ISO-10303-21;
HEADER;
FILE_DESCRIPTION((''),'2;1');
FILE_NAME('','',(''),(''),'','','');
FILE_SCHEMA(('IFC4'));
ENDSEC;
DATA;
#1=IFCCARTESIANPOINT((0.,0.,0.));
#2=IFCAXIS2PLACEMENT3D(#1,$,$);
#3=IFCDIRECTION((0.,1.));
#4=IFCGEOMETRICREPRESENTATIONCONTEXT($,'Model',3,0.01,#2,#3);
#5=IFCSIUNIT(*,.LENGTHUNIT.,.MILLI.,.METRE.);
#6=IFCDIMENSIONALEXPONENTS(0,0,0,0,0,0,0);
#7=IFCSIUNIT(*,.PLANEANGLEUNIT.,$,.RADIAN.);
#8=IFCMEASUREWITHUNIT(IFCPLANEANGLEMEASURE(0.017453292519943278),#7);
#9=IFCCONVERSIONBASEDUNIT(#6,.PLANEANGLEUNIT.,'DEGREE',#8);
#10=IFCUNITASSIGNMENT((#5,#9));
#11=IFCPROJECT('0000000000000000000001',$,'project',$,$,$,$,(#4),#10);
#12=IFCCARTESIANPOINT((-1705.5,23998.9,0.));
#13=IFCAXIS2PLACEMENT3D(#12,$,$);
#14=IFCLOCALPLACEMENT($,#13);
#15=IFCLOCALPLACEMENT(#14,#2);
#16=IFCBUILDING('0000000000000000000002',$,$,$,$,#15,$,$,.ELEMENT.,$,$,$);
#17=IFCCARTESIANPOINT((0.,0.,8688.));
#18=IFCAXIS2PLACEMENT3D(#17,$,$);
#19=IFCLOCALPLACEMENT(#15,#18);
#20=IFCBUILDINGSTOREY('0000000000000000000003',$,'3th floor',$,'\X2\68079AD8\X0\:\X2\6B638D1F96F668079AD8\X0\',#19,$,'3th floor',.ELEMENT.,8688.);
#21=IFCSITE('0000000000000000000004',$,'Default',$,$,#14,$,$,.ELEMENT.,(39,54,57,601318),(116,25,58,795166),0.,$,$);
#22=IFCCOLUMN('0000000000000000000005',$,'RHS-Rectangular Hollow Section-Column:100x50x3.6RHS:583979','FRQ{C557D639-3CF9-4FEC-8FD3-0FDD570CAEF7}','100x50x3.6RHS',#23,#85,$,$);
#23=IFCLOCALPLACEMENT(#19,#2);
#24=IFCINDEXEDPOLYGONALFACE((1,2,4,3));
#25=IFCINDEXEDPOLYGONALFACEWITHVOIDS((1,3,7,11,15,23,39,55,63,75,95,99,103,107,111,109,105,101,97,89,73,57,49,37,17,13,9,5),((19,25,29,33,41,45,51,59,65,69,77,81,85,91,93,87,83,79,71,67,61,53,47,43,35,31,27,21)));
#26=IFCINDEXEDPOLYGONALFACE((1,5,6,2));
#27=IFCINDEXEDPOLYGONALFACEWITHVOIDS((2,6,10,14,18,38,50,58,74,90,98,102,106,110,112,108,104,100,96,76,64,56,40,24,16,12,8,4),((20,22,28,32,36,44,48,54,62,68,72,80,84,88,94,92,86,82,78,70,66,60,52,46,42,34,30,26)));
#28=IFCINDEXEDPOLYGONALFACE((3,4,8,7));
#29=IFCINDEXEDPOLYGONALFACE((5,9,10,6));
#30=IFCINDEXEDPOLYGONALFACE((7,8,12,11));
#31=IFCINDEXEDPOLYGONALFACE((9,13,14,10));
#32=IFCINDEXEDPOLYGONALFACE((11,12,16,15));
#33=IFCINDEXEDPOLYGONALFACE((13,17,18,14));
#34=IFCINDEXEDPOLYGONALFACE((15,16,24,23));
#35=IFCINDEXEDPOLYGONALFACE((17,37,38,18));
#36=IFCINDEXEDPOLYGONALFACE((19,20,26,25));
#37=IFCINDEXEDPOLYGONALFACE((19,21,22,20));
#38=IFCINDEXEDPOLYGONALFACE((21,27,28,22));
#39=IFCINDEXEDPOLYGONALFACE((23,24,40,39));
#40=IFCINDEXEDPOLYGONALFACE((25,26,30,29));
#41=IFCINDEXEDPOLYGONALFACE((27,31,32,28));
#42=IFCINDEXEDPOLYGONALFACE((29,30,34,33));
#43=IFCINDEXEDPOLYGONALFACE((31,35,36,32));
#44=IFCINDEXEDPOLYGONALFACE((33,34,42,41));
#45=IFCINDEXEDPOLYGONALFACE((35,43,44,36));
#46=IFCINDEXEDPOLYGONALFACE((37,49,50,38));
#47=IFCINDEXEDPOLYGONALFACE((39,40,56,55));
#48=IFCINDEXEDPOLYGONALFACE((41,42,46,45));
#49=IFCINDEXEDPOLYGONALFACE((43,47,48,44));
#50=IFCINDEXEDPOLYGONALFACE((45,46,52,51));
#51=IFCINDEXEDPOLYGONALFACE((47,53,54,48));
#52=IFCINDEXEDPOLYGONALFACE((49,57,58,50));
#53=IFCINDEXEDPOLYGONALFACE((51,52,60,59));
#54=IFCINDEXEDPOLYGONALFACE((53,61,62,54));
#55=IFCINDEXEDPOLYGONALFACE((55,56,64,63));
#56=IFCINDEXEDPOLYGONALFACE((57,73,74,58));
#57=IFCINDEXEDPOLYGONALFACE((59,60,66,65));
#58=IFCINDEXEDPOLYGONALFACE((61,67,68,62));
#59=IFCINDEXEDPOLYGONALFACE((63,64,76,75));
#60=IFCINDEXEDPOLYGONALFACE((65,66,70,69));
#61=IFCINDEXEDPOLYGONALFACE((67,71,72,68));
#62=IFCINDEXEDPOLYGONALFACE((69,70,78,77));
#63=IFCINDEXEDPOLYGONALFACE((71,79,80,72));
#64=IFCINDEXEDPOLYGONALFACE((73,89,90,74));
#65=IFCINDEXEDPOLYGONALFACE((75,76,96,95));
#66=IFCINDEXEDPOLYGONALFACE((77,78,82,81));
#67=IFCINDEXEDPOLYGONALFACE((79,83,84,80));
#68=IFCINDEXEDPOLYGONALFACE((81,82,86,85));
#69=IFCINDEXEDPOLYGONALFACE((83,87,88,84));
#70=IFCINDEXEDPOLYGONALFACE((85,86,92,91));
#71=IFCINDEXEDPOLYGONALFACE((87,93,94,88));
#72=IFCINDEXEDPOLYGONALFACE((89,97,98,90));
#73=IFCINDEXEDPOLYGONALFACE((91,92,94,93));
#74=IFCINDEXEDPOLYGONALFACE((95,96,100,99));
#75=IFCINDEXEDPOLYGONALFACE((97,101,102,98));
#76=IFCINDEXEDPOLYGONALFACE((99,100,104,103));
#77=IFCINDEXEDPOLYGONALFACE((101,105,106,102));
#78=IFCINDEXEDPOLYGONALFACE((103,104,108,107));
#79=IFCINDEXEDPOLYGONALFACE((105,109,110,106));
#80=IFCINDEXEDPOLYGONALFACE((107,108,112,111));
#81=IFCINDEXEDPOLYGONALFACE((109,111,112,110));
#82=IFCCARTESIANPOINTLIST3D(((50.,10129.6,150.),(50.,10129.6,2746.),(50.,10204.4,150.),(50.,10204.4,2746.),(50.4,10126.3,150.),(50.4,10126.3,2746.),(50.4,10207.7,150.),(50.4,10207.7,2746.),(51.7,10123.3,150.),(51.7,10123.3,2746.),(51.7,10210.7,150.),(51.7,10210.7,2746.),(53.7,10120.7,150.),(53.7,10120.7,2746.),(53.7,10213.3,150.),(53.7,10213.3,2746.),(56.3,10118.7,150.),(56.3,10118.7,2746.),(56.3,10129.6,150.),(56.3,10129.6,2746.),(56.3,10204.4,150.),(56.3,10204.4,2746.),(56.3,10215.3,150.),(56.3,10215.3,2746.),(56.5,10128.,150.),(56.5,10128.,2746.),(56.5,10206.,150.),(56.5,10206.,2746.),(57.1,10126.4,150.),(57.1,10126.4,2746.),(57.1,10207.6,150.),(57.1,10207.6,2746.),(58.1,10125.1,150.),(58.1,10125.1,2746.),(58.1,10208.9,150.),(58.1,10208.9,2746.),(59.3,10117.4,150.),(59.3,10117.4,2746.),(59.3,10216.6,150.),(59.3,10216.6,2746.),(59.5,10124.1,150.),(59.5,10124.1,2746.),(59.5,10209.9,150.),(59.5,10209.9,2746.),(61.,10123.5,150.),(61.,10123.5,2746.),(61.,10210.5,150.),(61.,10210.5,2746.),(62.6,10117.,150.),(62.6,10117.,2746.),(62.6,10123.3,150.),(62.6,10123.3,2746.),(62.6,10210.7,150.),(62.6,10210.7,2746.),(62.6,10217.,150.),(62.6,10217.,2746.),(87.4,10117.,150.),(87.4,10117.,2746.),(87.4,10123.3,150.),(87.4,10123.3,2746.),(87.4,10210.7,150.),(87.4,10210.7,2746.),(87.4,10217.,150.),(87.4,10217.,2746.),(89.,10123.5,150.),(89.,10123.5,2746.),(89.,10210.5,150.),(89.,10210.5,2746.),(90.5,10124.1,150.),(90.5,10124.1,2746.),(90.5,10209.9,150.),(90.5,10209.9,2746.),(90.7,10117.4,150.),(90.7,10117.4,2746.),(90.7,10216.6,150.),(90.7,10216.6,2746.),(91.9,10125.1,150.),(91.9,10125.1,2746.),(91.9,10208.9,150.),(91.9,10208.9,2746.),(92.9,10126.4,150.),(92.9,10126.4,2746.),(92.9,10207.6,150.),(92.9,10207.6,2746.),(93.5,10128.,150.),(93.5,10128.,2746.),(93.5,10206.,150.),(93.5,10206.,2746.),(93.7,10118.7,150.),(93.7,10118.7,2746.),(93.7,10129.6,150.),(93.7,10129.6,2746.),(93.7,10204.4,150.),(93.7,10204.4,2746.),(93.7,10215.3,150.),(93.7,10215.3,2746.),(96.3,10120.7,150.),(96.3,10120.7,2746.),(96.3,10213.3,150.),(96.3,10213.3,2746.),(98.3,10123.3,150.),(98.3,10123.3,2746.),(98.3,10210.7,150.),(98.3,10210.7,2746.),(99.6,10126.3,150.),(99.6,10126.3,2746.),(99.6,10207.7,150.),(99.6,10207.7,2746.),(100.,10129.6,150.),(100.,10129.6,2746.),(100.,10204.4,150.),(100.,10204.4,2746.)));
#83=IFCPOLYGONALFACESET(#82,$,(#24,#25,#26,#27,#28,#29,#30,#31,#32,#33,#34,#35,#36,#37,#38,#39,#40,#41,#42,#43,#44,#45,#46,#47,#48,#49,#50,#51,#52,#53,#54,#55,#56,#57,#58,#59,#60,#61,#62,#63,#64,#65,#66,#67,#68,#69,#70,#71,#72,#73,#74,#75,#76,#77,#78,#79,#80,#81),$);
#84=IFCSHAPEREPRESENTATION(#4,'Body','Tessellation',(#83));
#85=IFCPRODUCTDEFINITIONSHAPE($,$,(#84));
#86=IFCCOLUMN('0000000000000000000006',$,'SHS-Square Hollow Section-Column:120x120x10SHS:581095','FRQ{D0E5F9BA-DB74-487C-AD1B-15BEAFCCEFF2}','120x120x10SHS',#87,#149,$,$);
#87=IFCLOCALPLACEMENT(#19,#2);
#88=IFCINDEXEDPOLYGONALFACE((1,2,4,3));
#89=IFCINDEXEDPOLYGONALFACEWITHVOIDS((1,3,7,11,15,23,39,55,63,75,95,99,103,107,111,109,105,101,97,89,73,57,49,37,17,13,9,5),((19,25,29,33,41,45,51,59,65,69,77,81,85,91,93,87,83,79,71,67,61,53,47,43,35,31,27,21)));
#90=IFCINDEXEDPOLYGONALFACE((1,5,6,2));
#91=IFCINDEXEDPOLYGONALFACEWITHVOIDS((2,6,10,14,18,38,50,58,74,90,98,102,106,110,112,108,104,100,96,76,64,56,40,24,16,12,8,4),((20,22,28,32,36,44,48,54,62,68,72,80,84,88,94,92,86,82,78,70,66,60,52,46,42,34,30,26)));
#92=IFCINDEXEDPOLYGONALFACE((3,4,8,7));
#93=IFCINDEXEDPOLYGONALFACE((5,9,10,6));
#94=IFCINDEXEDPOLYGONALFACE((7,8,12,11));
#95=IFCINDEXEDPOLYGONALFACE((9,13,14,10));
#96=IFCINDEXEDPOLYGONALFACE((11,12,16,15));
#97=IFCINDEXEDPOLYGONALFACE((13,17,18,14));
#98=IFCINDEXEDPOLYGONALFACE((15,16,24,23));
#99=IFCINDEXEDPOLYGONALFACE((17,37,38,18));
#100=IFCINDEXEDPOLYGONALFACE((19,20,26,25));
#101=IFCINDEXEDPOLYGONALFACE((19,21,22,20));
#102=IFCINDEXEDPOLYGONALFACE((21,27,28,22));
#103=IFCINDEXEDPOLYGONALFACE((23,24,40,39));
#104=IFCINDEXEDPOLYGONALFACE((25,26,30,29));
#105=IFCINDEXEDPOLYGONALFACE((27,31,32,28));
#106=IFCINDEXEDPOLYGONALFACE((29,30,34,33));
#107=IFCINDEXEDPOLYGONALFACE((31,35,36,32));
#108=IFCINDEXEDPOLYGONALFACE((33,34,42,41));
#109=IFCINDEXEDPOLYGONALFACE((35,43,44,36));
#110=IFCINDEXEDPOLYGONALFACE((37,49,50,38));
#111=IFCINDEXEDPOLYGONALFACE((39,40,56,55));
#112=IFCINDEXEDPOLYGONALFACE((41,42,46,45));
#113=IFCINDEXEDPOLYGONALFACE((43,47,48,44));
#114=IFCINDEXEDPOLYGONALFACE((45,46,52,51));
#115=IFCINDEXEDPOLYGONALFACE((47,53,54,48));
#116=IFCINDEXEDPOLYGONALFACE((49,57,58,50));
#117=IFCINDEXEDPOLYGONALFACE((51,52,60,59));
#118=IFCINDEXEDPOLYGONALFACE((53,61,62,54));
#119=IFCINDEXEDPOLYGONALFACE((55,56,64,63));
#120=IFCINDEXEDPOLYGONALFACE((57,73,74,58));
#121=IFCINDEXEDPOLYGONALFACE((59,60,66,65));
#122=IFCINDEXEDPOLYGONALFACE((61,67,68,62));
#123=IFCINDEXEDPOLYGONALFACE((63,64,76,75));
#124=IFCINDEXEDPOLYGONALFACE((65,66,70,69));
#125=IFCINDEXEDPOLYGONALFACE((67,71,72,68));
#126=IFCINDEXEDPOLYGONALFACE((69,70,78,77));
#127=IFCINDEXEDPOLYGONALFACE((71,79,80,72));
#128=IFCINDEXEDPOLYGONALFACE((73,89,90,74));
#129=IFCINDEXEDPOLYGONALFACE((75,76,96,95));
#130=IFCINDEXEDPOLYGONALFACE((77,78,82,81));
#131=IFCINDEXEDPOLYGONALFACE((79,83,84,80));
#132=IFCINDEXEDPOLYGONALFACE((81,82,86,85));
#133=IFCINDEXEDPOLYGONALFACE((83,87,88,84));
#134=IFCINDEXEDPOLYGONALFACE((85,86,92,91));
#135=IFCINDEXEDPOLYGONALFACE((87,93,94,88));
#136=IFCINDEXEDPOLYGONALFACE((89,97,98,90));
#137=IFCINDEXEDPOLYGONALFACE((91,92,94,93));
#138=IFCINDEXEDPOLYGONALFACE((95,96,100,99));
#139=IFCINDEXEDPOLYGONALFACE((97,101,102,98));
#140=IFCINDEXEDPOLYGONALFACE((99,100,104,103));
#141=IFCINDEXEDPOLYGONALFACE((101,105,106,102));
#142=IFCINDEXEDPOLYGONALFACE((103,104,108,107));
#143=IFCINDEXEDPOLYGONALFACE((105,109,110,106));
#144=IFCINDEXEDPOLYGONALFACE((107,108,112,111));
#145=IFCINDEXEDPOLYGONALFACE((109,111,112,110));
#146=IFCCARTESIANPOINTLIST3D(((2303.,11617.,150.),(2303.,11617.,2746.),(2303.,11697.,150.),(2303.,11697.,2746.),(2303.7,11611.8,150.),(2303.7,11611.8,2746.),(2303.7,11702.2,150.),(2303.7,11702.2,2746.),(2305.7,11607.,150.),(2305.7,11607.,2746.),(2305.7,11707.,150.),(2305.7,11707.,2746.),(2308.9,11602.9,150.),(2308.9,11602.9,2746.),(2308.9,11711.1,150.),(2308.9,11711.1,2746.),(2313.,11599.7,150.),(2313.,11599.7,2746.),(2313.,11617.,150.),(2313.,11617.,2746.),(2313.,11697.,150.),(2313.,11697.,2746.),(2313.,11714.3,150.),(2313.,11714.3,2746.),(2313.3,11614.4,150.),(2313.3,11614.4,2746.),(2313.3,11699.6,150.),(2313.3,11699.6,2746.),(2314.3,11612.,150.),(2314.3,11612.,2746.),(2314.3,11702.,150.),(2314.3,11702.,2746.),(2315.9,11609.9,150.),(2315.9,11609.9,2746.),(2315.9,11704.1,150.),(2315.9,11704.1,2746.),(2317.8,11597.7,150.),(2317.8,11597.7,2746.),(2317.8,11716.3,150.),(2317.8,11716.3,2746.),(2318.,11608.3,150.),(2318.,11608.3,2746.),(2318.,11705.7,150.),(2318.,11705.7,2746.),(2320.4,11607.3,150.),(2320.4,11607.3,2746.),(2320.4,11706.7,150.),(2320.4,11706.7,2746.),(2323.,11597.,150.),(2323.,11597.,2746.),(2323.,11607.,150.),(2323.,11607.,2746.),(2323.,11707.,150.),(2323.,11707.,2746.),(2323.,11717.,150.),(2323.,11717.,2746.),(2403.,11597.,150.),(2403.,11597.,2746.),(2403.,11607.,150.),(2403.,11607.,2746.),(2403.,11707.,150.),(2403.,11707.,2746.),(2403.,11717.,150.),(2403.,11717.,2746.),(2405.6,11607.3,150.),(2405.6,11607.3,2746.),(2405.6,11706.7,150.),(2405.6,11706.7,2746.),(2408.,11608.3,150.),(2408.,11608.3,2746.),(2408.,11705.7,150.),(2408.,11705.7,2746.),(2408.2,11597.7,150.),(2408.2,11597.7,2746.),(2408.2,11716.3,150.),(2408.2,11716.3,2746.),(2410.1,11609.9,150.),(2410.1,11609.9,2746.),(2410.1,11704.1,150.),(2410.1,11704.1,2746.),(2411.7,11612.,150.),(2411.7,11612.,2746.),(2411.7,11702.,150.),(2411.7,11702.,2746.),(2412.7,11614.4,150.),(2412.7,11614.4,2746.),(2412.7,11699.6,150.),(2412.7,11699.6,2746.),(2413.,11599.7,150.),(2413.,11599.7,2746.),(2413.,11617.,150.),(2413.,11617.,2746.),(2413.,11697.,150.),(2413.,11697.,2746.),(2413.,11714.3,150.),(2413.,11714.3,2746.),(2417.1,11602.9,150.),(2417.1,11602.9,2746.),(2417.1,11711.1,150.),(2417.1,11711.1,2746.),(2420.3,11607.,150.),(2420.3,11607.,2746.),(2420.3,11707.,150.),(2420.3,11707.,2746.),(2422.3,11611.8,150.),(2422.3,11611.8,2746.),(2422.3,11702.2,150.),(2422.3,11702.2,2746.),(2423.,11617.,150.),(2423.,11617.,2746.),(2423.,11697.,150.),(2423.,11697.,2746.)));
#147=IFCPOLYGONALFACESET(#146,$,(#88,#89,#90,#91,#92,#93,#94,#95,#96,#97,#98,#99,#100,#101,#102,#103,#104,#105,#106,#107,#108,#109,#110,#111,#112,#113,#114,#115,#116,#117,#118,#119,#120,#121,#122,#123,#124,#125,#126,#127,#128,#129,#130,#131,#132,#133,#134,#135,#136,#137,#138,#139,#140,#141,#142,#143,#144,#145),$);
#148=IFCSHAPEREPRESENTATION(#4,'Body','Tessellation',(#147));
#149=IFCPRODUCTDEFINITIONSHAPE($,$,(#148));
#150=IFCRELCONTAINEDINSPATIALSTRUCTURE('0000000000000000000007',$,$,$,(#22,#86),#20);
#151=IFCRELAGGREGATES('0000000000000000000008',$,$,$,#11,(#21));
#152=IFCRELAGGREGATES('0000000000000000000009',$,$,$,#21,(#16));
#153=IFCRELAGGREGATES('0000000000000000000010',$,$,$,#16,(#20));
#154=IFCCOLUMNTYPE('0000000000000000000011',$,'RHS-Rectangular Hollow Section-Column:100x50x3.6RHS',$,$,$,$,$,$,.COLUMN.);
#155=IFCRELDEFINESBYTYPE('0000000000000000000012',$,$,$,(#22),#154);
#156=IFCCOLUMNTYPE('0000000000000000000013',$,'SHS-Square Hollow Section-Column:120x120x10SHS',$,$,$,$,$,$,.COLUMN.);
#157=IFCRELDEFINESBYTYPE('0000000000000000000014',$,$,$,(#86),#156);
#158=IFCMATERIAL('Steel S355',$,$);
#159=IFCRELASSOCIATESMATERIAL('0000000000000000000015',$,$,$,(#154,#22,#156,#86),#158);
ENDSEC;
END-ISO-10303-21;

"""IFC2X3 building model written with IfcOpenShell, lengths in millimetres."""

from ifc_helpers import new_model, entity, si_unit, converted_unit, direction, frame, origin, origin_2d, place, context, project, spatial, hollow_rectangle, extrude, clip, halfspace, material, type_object, element, save


model = new_model("IFC2X3")

# Units and contexts
model_context = context("Model", 3, precision=0.01, world=origin(), true_north=direction((0.0, 1.0)))
ifc_project = project(units=[si_unit("LENGTHUNIT", "METRE", prefix="MILLI"), converted_unit("PLANEANGLEUNIT", "DEGREE", entity("IfcPlaneAngleMeasure", 0.017453292519943278), si_unit("PLANEANGLEUNIT", "RADIAN"), dimensions=[0, 0, 0, 0, 0, 0, 0])], contexts=[model_context])

# Site, building, storey
site_placement = place(None, frame((-1705.5, 23998.9, 0.0)))
site = spatial("IfcSite", under=ifc_project, at=site_placement, Name="Default", CompositionType="ELEMENT", RefLatitude=(39, 54, 57, 601318), RefLongitude=(116, 25, 58, 795166), RefElevation=0.0)
building_placement = place(site_placement, origin())
building = spatial("IfcBuilding", under=site, at=building_placement, CompositionType="ELEMENT")
storey_placement = place(building_placement, frame((0.0, 0.0, 8688.0)))
storey = spatial("IfcBuildingStorey", under=building, at=storey_placement, Name="3th floor", ObjectType="标高:正负零标高", LongName="3th floor", CompositionType="ELEMENT", Elevation=8688.0)

# Shared definitions
ifc_material_1 = material(Name="Steel S355")

# Columns
column_type_1 = type_object("IfcColumnType", Name="RHS-Rectangular Hollow Section-Column:100x50x3.6RHS", PredefinedType="COLUMN", material=ifc_material_1)
column_1_placement = place(storey_placement, frame((75.0, 10167.0, 2746.0), z_axis=(0.0, 0.0, 1.0), x_axis=(-1.0, 0.0, 0.0)))
element("IfcColumn", 1, at=column_1_placement, inside=storey, type_object=column_type_1, material=ifc_material_1, Name="RHS-Rectangular Hollow Section-Column:100x50x3.6RHS:583979", Description="FRQ{C557D639-3CF9-4FEC-8FD3-0FDD570CAEF7}", ObjectType="100x50x3.6RHS", context=model_context, shape_type="Clipping", body=[
    clip(extrude(hollow_rectangle(XDim=50.0, YDim=100.0, WallThickness=6.3, InnerFilletRadius=6.3, OuterFilletRadius=12.6, at=origin_2d()), origin(), (0.0, 0.0, -1.0), 2651.9), halfspace(frame((75.0, 10167.0, -2596.0), z_axis=(0.0, 0.0, 1.0), x_axis=(-1.0, 0.0, 0.0)), True)),
])
column_type_2 = type_object("IfcColumnType", Name="SHS-Square Hollow Section-Column:120x120x10SHS", PredefinedType="COLUMN", material=ifc_material_1)
column_2_placement = place(storey_placement, frame((2363.0, 11657.0, 2830.9), z_axis=(0.0, 0.0, 1.0), x_axis=(0.0, -1.0, 0.0)))
element("IfcColumn", 2, at=column_2_placement, inside=storey, type_object=column_type_2, material=ifc_material_1, Name="SHS-Square Hollow Section-Column:120x120x10SHS:581095", Description="FRQ{D0E5F9BA-DB74-487C-AD1B-15BEAFCCEFF2}", ObjectType="120x120x10SHS", context=model_context, shape_type="Clipping", body=[
    clip(clip(extrude(hollow_rectangle(XDim=120.0, YDim=120.0, WallThickness=10.0, InnerFilletRadius=10.0, OuterFilletRadius=20.0, at=origin_2d()), origin(), (0.0, 0.0, -1.0), 2765.7), halfspace(frame((11657.0, -2363.0, -2680.9), z_axis=(0.0, 0.0, 1.0), x_axis=(0.0, 1.0, 0.0)), True)), halfspace(frame((11657.0, -2363.0, -84.9), z_axis=(0.0, 0.0, -1.0), x_axis=(0.0, -1.0, 0.0)), True)),
])

save(model, "model.ifc")
